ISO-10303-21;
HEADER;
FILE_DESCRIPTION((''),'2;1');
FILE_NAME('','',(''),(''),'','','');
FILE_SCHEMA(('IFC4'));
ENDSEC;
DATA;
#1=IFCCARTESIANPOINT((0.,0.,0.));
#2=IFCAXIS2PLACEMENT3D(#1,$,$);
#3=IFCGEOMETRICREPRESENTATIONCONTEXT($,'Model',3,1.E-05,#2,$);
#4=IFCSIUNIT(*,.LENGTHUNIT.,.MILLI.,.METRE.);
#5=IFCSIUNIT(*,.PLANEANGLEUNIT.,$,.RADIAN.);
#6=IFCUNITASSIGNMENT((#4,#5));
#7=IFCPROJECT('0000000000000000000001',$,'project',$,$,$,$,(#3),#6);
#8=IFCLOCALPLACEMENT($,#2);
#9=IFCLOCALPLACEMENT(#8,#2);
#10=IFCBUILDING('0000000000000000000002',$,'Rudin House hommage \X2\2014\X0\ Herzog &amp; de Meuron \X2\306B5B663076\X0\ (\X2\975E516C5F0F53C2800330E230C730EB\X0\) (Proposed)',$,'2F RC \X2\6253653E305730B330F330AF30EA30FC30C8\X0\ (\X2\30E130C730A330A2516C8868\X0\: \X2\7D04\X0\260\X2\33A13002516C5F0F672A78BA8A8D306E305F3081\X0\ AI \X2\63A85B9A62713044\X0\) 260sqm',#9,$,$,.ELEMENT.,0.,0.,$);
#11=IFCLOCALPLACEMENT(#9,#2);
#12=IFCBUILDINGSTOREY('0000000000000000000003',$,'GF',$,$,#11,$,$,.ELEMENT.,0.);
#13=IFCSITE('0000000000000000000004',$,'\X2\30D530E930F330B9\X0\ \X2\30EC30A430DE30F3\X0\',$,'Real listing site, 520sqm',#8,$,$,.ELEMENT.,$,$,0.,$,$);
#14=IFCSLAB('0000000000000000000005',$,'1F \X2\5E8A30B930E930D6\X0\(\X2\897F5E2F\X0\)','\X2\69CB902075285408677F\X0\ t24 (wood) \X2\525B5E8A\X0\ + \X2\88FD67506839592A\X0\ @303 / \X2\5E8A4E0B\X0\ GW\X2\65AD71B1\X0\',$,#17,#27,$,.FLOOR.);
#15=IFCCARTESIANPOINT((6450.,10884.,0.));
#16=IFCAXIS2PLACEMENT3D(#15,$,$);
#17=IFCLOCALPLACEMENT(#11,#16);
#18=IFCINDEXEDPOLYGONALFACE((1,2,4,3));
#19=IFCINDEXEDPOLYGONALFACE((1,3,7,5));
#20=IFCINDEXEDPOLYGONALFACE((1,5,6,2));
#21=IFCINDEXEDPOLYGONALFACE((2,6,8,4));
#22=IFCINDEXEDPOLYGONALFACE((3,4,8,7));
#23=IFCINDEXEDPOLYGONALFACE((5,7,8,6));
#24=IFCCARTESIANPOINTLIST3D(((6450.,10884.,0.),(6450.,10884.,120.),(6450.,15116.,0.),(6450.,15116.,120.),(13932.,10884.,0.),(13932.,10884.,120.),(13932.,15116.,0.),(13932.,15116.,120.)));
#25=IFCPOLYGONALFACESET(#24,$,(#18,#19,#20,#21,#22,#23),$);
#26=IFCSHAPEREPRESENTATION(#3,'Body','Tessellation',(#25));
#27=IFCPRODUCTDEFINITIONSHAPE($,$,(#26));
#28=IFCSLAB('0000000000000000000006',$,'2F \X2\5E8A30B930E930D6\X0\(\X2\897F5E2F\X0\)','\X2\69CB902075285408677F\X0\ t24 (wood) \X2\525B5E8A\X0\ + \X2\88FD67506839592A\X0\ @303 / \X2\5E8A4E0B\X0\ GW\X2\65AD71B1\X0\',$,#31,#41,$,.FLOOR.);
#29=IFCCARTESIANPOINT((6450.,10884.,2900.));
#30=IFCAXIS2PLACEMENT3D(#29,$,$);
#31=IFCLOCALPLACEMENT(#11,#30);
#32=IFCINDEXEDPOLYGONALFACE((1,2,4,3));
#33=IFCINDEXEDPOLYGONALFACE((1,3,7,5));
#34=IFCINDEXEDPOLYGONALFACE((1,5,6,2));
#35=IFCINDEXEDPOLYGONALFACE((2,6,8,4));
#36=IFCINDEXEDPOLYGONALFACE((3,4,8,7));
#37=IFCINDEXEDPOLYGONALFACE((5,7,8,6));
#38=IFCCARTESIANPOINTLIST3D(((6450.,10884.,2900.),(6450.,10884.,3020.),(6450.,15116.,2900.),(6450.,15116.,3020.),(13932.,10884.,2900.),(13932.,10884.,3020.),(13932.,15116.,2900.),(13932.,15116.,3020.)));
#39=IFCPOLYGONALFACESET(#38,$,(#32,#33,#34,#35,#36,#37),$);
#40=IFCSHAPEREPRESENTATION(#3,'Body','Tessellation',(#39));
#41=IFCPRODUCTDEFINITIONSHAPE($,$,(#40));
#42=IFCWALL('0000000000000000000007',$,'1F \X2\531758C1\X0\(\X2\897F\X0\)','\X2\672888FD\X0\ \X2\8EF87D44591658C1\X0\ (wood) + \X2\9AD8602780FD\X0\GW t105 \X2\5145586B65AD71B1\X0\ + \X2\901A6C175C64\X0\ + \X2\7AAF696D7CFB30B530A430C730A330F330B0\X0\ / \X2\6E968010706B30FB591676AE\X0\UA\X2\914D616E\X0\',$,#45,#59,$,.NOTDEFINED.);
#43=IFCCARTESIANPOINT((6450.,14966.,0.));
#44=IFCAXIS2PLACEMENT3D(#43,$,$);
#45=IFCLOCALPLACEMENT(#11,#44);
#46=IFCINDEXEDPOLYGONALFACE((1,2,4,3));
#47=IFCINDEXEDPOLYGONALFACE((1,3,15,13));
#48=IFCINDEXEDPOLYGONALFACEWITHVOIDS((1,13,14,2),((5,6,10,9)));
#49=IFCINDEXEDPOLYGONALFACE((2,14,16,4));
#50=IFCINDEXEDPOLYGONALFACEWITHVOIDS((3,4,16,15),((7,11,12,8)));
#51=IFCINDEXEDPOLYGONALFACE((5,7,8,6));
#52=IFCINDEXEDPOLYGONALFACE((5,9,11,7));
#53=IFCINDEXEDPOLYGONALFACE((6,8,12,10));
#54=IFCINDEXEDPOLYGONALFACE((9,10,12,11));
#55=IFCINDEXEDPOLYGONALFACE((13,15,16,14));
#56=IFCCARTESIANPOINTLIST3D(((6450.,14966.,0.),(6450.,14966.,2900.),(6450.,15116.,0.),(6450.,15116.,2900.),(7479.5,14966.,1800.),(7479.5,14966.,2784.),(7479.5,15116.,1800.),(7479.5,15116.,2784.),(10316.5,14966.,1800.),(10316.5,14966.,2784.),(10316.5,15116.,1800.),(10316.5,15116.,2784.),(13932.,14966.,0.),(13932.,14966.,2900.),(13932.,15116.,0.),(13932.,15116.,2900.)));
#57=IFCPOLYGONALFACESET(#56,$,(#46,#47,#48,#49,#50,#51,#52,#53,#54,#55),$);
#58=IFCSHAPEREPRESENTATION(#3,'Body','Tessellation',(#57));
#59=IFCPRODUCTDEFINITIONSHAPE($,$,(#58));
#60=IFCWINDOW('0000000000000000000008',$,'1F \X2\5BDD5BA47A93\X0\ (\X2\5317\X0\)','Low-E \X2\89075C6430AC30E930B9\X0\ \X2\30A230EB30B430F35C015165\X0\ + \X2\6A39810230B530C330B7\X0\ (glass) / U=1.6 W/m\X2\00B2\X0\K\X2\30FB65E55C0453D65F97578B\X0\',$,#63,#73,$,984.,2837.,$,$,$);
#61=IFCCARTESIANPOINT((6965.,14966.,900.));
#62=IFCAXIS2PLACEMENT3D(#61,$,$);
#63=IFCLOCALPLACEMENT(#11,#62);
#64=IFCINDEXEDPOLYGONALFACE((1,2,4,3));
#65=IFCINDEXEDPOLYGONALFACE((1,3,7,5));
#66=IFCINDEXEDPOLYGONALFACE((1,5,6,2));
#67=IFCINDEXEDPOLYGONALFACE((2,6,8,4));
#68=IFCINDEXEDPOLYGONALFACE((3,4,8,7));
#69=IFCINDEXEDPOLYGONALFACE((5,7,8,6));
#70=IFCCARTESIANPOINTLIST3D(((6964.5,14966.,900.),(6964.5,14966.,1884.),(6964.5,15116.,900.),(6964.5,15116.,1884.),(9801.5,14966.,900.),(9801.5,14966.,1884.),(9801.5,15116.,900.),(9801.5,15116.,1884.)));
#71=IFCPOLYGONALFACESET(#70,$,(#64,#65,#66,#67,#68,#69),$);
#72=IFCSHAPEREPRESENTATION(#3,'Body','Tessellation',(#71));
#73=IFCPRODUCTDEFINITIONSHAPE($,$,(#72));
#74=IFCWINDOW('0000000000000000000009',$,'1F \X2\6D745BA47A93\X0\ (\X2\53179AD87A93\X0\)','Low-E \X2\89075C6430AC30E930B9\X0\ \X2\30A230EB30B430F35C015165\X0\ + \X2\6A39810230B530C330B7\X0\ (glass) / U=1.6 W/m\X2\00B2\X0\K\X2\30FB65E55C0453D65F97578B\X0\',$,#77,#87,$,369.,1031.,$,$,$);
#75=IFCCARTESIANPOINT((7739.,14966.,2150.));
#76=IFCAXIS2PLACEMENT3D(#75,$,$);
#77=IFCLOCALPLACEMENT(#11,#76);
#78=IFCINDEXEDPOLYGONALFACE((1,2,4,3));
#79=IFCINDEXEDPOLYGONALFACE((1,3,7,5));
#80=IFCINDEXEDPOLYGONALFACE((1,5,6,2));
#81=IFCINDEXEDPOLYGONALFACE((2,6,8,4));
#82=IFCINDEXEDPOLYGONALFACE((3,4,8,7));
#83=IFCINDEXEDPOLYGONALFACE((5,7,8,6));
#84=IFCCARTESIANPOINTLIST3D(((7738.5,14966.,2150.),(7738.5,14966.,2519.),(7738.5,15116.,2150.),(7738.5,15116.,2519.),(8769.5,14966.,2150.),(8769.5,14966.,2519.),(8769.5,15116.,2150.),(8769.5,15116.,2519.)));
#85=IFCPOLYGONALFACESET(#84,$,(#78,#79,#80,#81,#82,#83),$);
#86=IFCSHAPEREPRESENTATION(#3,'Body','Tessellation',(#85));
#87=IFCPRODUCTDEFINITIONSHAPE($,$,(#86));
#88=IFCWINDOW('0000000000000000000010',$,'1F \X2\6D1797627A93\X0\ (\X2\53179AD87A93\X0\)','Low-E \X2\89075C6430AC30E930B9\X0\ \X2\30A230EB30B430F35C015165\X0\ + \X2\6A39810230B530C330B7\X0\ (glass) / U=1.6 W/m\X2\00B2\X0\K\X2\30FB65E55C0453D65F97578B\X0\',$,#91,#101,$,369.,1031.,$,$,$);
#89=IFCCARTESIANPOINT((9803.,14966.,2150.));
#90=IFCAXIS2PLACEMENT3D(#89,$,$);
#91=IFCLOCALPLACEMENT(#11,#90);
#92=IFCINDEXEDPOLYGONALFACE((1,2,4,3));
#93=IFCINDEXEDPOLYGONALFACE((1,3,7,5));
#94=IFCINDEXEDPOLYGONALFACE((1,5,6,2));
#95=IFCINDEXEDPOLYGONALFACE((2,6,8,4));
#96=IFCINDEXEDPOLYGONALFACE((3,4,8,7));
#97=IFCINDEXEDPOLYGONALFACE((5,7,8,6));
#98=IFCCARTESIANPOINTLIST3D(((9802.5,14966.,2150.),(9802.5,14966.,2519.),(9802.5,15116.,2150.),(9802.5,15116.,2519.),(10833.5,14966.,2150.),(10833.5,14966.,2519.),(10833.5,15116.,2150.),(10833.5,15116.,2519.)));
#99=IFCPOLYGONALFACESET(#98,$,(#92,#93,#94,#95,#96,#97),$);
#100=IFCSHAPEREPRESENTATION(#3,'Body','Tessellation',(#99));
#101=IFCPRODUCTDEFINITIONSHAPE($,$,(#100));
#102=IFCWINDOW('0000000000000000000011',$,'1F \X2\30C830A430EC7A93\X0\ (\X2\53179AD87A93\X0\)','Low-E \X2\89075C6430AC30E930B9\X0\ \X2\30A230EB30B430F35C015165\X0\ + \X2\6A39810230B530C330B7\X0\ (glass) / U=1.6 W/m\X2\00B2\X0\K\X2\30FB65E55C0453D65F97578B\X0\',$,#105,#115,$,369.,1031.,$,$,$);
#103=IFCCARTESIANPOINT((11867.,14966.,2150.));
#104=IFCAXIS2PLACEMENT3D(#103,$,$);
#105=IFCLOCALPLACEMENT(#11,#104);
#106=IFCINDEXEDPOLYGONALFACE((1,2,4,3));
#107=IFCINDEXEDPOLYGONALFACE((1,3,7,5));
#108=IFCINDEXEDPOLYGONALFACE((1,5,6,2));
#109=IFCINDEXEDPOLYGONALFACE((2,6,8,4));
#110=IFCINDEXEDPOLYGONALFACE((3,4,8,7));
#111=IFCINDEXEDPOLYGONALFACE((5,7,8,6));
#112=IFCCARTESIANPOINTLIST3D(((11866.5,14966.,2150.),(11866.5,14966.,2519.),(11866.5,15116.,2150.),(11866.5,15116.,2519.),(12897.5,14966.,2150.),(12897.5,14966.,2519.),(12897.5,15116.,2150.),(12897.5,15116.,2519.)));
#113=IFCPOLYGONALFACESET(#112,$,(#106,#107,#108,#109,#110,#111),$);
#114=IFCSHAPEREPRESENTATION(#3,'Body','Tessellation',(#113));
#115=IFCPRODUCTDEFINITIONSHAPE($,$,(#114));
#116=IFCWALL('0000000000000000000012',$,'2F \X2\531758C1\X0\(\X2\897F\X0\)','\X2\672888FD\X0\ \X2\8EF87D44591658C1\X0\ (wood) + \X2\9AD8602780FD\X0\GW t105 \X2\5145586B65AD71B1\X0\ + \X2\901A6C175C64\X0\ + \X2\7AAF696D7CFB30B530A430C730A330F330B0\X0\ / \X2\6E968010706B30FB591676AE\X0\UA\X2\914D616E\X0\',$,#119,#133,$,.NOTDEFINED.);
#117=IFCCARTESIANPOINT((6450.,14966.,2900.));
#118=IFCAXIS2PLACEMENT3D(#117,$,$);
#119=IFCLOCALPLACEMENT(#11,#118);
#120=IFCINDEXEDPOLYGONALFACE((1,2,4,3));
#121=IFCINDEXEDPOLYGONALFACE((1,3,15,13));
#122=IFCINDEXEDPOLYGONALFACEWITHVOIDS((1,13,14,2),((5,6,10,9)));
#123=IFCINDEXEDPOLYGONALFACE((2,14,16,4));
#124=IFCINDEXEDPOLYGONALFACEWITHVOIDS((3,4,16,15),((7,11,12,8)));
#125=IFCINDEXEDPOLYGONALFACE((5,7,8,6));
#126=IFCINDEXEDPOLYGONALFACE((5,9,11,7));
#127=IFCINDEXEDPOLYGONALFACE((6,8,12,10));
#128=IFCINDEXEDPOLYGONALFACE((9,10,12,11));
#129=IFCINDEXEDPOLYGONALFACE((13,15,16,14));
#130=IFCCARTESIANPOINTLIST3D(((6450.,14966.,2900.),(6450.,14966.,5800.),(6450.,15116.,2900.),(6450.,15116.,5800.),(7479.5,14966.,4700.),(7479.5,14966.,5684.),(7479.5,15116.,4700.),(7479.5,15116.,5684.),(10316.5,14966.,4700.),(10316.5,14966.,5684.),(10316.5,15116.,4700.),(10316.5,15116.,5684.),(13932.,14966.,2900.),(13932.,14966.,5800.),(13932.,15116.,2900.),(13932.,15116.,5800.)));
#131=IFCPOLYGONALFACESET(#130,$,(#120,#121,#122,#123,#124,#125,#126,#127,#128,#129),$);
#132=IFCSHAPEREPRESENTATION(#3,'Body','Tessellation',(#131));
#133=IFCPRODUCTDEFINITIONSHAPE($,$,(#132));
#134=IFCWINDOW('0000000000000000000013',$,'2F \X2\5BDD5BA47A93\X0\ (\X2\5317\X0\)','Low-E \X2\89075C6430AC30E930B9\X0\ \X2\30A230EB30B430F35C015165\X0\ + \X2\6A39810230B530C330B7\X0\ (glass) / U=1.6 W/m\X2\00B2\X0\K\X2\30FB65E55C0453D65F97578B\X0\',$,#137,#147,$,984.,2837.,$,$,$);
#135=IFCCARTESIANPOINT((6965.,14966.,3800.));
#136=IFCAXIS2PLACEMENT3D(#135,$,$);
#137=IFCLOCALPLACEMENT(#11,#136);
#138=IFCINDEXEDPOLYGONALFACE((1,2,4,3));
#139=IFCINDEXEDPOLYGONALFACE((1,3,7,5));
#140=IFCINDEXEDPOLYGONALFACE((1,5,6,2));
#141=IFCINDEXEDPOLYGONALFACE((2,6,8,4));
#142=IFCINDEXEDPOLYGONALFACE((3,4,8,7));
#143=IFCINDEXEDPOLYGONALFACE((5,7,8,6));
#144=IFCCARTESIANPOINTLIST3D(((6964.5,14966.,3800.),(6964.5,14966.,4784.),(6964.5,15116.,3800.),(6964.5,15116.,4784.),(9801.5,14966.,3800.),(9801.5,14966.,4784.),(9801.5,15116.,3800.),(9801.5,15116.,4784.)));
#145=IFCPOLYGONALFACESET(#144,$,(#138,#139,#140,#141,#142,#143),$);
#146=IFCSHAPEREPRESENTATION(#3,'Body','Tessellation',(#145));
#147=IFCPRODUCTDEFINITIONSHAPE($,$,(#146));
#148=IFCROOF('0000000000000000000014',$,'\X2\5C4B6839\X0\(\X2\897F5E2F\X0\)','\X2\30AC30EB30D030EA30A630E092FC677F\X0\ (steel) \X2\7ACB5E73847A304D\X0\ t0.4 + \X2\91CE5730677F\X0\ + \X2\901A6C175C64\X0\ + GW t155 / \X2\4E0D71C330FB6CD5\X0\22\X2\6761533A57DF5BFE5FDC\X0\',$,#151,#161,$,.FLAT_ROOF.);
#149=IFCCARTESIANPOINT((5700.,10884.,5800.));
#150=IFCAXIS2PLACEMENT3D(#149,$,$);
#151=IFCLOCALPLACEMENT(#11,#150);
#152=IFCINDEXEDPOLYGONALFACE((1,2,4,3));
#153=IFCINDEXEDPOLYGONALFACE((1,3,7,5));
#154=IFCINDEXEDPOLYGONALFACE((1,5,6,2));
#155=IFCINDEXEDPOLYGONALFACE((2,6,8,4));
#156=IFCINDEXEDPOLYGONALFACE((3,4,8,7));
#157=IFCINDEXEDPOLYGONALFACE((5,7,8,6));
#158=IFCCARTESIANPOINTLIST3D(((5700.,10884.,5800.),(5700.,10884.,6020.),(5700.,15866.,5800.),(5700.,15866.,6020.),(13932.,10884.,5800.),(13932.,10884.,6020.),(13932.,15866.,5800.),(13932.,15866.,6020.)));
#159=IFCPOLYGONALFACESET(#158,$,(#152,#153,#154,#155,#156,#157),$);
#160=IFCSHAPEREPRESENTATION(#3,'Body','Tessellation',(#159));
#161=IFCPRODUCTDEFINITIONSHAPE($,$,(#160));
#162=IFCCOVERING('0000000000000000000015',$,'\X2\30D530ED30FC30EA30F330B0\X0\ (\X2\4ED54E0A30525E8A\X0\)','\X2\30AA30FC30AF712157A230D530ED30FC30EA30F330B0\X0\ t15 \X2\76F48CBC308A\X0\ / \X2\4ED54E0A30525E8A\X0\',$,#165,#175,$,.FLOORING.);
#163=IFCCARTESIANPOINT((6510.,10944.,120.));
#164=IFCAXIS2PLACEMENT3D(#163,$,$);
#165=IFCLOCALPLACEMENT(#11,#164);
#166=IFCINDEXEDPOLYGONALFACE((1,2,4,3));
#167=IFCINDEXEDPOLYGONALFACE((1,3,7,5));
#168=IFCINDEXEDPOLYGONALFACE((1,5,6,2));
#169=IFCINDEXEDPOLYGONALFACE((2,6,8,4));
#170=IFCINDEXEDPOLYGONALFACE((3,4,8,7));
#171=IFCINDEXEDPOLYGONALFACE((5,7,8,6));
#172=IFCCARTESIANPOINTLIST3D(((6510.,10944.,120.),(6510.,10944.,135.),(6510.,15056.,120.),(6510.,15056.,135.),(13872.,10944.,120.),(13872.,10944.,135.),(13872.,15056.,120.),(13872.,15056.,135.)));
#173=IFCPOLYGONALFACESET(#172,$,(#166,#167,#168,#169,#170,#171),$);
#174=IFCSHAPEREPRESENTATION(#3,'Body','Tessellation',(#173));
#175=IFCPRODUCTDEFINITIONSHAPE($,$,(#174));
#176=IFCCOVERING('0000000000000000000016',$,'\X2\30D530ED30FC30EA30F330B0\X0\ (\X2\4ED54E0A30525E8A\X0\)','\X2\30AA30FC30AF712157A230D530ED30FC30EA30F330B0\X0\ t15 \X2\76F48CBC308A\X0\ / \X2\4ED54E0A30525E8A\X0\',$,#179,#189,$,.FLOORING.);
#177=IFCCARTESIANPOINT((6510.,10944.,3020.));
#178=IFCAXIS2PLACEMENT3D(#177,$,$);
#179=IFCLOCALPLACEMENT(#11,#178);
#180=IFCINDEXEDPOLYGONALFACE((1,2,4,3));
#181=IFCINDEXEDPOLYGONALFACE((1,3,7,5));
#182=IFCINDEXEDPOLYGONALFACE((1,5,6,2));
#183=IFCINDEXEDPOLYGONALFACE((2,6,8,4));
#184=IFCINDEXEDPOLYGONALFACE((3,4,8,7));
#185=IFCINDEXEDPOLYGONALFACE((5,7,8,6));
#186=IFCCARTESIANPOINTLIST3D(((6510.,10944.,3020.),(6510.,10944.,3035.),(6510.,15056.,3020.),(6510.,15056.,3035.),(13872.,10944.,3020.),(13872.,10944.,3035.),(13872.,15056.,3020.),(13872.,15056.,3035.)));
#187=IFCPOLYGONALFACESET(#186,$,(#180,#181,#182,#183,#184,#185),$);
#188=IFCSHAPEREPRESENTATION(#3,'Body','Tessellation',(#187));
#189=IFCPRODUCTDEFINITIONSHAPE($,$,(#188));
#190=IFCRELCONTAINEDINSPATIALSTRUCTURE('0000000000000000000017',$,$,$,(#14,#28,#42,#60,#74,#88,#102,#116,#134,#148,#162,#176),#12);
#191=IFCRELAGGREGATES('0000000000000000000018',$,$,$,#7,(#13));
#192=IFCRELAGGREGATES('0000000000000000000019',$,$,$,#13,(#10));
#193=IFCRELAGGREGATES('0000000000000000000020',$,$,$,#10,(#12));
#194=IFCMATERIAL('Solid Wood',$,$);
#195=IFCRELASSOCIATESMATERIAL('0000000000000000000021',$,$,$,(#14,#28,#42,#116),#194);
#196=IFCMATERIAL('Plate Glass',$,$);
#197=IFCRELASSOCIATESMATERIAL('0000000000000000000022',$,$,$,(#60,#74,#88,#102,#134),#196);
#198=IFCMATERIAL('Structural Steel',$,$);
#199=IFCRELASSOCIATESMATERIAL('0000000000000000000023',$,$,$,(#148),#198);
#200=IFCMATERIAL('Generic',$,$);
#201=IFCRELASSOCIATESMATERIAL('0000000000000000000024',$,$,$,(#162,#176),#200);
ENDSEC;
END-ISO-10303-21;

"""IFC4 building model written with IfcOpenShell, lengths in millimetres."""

from ifc_helpers import new_model, si_unit, frame, frame_2d, origin, place, context, project, spatial, rectangle, extrude, material, element, fill, save


model = new_model("IFC4")

# Units and contexts
model_context = context("Model", 3, precision=1e-05, world=origin())
ifc_project = project(units=[si_unit("LENGTHUNIT", "METRE", prefix="MILLI"), si_unit("PLANEANGLEUNIT", "RADIAN")], contexts=[model_context])

# Site, building, storey
site_placement = place(None, origin())
site = spatial("IfcSite", under=ifc_project, at=site_placement, Name="フランス レイマン", ObjectType="Real listing site, 520sqm", CompositionType="ELEMENT", RefElevation=0.0)
building_placement = place(site_placement, origin())
building = spatial("IfcBuilding", under=site, at=building_placement, Name="Rudin House hommage — Herzog &amp; de Meuron に学ぶ (非公式参考モデル) (Proposed)", ObjectType="2F RC 打放しコンクリート (メディア公表: 約260㎡。公式未確認のため AI 推定扱い) 260sqm", CompositionType="ELEMENT", ElevationOfRefHeight=0.0, ElevationOfTerrain=0.0)
storey_placement = place(building_placement, origin())
storey = spatial("IfcBuildingStorey", under=building, at=storey_placement, Name="GF", CompositionType="ELEMENT", Elevation=0.0)

# Slabs
ifc_material_1 = material(Name="Solid Wood")
slab_1_placement = place(storey_placement, frame((6450.0, 10884.0, 0.0)))
element("IfcSlab", 1, at=slab_1_placement, inside=storey, material=ifc_material_1, Name="1F 床スラブ(西帯)", Description="構造用合板 t24 (wood) 剛床 + 製材根太 @303 / 床下 GW断熱", PredefinedType="FLOOR", context=model_context, shape_type="SweptSolid", body=[
    extrude(rectangle(XDim=7482.0, YDim=4232.0, at=frame_2d((3741.0, 2116.0))), frame((6450.0, 10884.0, 0.0)), (0.0, 0.0, 1.0), 120.0),
])
slab_2_placement = place(storey_placement, frame((6450.0, 10884.0, 2900.0)))
element("IfcSlab", 2, at=slab_2_placement, inside=storey, material=ifc_material_1, Name="2F 床スラブ(西帯)", Description="構造用合板 t24 (wood) 剛床 + 製材根太 @303 / 床下 GW断熱", PredefinedType="FLOOR", context=model_context, shape_type="SweptSolid", body=[
    extrude(rectangle(XDim=7482.0, YDim=4232.0, at=frame_2d((3741.0, 2116.0))), frame((6450.0, 10884.0, 2900.0)), (0.0, 0.0, 1.0), 120.0),
])

# Wall, openings, windows
wall_1_placement = place(storey_placement, frame((6450.0, 14966.0, 0.0)))
wall_1 = element("IfcWall", 3, at=wall_1_placement, inside=storey, material=ifc_material_1, Name="1F 北壁(西)", Description="木製 軸組外壁 (wood) + 高性能GW t105 充填断熱 + 通気層 + 窯業系サイディング / 準耐火・外皮UA配慮", PredefinedType="NOTDEFINED", context=model_context, shape_type="SweptSolid", body=[
    extrude(rectangle(XDim=7482.0, YDim=150.0, at=frame_2d((3741.0, 75.0))), frame((6450.0, 14966.0, 0.0)), (0.0, 0.0, 1.0), 2900.0),
])
opening_1_placement = place(storey_placement, frame((6965.0, 14966.0, 900.0)))
opening_1 = element("IfcOpeningElement", 4, at=opening_1_placement, cuts=wall_1, PredefinedType="NOTDEFINED", context=model_context, shape_type="SweptSolid", body=[
    extrude(rectangle(XDim=2837.0, YDim=150.0, at=frame_2d((1418.0, 75.0))), frame((6965.0, 14966.0, 900.0)), (0.0, 0.0, 1.0), 984.0),
])
opening_2_placement = place(storey_placement, frame((7739.0, 14966.0, 2150.0)))
opening_2 = element("IfcOpeningElement", 5, at=opening_2_placement, cuts=wall_1, PredefinedType="NOTDEFINED", context=model_context, shape_type="SweptSolid", body=[
    extrude(rectangle(XDim=1031.0, YDim=150.0, at=frame_2d((515.0, 75.0))), frame((7739.0, 14966.0, 2150.0)), (0.0, 0.0, 1.0), 369.0),
])
opening_3_placement = place(storey_placement, frame((9803.0, 14966.0, 2150.0)))
opening_3 = element("IfcOpeningElement", 6, at=opening_3_placement, cuts=wall_1, PredefinedType="NOTDEFINED", context=model_context, shape_type="SweptSolid", body=[
    extrude(rectangle(XDim=1031.0, YDim=150.0, at=frame_2d((515.0, 75.0))), frame((9803.0, 14966.0, 2150.0)), (0.0, 0.0, 1.0), 369.0),
])
opening_4_placement = place(storey_placement, frame((11867.0, 14966.0, 2150.0)))
opening_4 = element("IfcOpeningElement", 7, at=opening_4_placement, cuts=wall_1, PredefinedType="NOTDEFINED", context=model_context, shape_type="SweptSolid", body=[
    extrude(rectangle(XDim=1031.0, YDim=150.0, at=frame_2d((515.0, 75.0))), frame((11867.0, 14966.0, 2150.0)), (0.0, 0.0, 1.0), 369.0),
])
ifc_material_2 = material(Name="Plate Glass")
window_1_placement = place(storey_placement, frame((6965.0, 14966.0, 900.0)))
window_1 = element("IfcWindow", 8, at=window_1_placement, inside=storey, material=ifc_material_2, Name="1F 寝室窓 (北)", Description="Low-E 複層ガラス アルゴン封入 + 樹脂サッシ (glass) / U=1.6 W/m²K・日射取得型", OverallHeight=984.0, OverallWidth=2837.0, context=model_context, shape_type="SweptSolid", body=[
    extrude(rectangle(XDim=2837.0, YDim=150.0, at=frame_2d((1418.0, 75.0))), frame((6965.0, 14966.0, 900.0)), (0.0, 0.0, 1.0), 984.0),
])
fill(opening_1, window_1)
window_2_placement = place(storey_placement, frame((7739.0, 14966.0, 2150.0)))
window_2 = element("IfcWindow", 9, at=window_2_placement, inside=storey, material=ifc_material_2, Name="1F 浴室窓 (北高窓)", Description="Low-E 複層ガラス アルゴン封入 + 樹脂サッシ (glass) / U=1.6 W/m²K・日射取得型", OverallHeight=369.0, OverallWidth=1031.0, context=model_context, shape_type="SweptSolid", body=[
    extrude(rectangle(XDim=1031.0, YDim=150.0, at=frame_2d((515.0, 75.0))), frame((7739.0, 14966.0, 2150.0)), (0.0, 0.0, 1.0), 369.0),
])
fill(opening_2, window_2)
window_3_placement = place(storey_placement, frame((9803.0, 14966.0, 2150.0)))
window_3 = element("IfcWindow", 10, at=window_3_placement, inside=storey, material=ifc_material_2, Name="1F 洗面窓 (北高窓)", Description="Low-E 複層ガラス アルゴン封入 + 樹脂サッシ (glass) / U=1.6 W/m²K・日射取得型", OverallHeight=369.0, OverallWidth=1031.0, context=model_context, shape_type="SweptSolid", body=[
    extrude(rectangle(XDim=1031.0, YDim=150.0, at=frame_2d((515.0, 75.0))), frame((9803.0, 14966.0, 2150.0)), (0.0, 0.0, 1.0), 369.0),
])
fill(opening_3, window_3)
window_4_placement = place(storey_placement, frame((11867.0, 14966.0, 2150.0)))
window_4 = element("IfcWindow", 11, at=window_4_placement, inside=storey, material=ifc_material_2, Name="1F トイレ窓 (北高窓)", Description="Low-E 複層ガラス アルゴン封入 + 樹脂サッシ (glass) / U=1.6 W/m²K・日射取得型", OverallHeight=369.0, OverallWidth=1031.0, context=model_context, shape_type="SweptSolid", body=[
    extrude(rectangle(XDim=1031.0, YDim=150.0, at=frame_2d((515.0, 75.0))), frame((11867.0, 14966.0, 2150.0)), (0.0, 0.0, 1.0), 369.0),
])
fill(opening_4, window_4)

# Wall, opening, window
wall_2_placement = place(storey_placement, frame((6450.0, 14966.0, 2900.0)))
wall_2 = element("IfcWall", 12, at=wall_2_placement, inside=storey, material=ifc_material_1, Name="2F 北壁(西)", Description="木製 軸組外壁 (wood) + 高性能GW t105 充填断熱 + 通気層 + 窯業系サイディング / 準耐火・外皮UA配慮", PredefinedType="NOTDEFINED", context=model_context, shape_type="SweptSolid", body=[
    extrude(rectangle(XDim=7482.0, YDim=150.0, at=frame_2d((3741.0, 75.0))), frame((6450.0, 14966.0, 2900.0)), (0.0, 0.0, 1.0), 2900.0),
])
opening_5_placement = place(storey_placement, frame((6965.0, 14966.0, 3800.0)))
opening_5 = element("IfcOpeningElement", 13, at=opening_5_placement, cuts=wall_2, PredefinedType="NOTDEFINED", context=model_context, shape_type="SweptSolid", body=[
    extrude(rectangle(XDim=2837.0, YDim=150.0, at=frame_2d((1418.0, 75.0))), frame((6965.0, 14966.0, 3800.0)), (0.0, 0.0, 1.0), 984.0),
])
window_5_placement = place(storey_placement, frame((6965.0, 14966.0, 3800.0)))
window_5 = element("IfcWindow", 14, at=window_5_placement, inside=storey, material=ifc_material_2, Name="2F 寝室窓 (北)", Description="Low-E 複層ガラス アルゴン封入 + 樹脂サッシ (glass) / U=1.6 W/m²K・日射取得型", OverallHeight=984.0, OverallWidth=2837.0, context=model_context, shape_type="SweptSolid", body=[
    extrude(rectangle(XDim=2837.0, YDim=150.0, at=frame_2d((1418.0, 75.0))), frame((6965.0, 14966.0, 3800.0)), (0.0, 0.0, 1.0), 984.0),
])
fill(opening_5, window_5)

# Roof
ifc_material_3 = material(Name="Structural Steel")
for number, where, name in (
    (15, (5700.0, 10884.0, 5800.0), "屋根(西帯)"),
):
    element("IfcRoof", number, at=place(storey_placement, frame(where)), inside=storey, material=ifc_material_3, Name=name, Description="ガルバリウム鋼板 (steel) 立平葺き t0.4 + 野地板 + 通気層 + GW t155 / 不燃・法22条区域対応", PredefinedType="FLAT_ROOF", context=model_context, shape_type="SweptSolid", body=[
        extrude(rectangle(XDim=8232.0, YDim=4982.0, at=frame_2d((4116.0, 2491.0))), frame((5700.0, 10884.0, 5800.0)), (0.0, 0.0, 1.0), 220.0),
    ])

# Coverings
ifc_material_4 = material(Name="Generic")
covering_1_placement = place(storey_placement, frame((6510.0, 10944.0, 120.0)))
element("IfcCovering", 16, at=covering_1_placement, inside=storey, material=ifc_material_4, Name="フローリング (仕上げ床)", Description="オーク無垢フローリング t15 直貼り / 仕上げ床", PredefinedType="FLOORING", context=model_context, shape_type="SweptSolid", body=[
    extrude(rectangle(XDim=7362.0, YDim=4112.0, at=frame_2d((3681.0, 2056.0))), frame((6510.0, 10944.0, 120.0)), (0.0, 0.0, 1.0), 15.0),
])
covering_2_placement = place(storey_placement, frame((6510.0, 10944.0, 3020.0)))
element("IfcCovering", 17, at=covering_2_placement, inside=storey, material=ifc_material_4, Name="フローリング (仕上げ床)", Description="オーク無垢フローリング t15 直貼り / 仕上げ床", PredefinedType="FLOORING", context=model_context, shape_type="SweptSolid", body=[
    extrude(rectangle(XDim=7362.0, YDim=4112.0, at=frame_2d((3681.0, 2056.0))), frame((6510.0, 10944.0, 3020.0)), (0.0, 0.0, 1.0), 15.0),
])

save(model, "model.ifc")
